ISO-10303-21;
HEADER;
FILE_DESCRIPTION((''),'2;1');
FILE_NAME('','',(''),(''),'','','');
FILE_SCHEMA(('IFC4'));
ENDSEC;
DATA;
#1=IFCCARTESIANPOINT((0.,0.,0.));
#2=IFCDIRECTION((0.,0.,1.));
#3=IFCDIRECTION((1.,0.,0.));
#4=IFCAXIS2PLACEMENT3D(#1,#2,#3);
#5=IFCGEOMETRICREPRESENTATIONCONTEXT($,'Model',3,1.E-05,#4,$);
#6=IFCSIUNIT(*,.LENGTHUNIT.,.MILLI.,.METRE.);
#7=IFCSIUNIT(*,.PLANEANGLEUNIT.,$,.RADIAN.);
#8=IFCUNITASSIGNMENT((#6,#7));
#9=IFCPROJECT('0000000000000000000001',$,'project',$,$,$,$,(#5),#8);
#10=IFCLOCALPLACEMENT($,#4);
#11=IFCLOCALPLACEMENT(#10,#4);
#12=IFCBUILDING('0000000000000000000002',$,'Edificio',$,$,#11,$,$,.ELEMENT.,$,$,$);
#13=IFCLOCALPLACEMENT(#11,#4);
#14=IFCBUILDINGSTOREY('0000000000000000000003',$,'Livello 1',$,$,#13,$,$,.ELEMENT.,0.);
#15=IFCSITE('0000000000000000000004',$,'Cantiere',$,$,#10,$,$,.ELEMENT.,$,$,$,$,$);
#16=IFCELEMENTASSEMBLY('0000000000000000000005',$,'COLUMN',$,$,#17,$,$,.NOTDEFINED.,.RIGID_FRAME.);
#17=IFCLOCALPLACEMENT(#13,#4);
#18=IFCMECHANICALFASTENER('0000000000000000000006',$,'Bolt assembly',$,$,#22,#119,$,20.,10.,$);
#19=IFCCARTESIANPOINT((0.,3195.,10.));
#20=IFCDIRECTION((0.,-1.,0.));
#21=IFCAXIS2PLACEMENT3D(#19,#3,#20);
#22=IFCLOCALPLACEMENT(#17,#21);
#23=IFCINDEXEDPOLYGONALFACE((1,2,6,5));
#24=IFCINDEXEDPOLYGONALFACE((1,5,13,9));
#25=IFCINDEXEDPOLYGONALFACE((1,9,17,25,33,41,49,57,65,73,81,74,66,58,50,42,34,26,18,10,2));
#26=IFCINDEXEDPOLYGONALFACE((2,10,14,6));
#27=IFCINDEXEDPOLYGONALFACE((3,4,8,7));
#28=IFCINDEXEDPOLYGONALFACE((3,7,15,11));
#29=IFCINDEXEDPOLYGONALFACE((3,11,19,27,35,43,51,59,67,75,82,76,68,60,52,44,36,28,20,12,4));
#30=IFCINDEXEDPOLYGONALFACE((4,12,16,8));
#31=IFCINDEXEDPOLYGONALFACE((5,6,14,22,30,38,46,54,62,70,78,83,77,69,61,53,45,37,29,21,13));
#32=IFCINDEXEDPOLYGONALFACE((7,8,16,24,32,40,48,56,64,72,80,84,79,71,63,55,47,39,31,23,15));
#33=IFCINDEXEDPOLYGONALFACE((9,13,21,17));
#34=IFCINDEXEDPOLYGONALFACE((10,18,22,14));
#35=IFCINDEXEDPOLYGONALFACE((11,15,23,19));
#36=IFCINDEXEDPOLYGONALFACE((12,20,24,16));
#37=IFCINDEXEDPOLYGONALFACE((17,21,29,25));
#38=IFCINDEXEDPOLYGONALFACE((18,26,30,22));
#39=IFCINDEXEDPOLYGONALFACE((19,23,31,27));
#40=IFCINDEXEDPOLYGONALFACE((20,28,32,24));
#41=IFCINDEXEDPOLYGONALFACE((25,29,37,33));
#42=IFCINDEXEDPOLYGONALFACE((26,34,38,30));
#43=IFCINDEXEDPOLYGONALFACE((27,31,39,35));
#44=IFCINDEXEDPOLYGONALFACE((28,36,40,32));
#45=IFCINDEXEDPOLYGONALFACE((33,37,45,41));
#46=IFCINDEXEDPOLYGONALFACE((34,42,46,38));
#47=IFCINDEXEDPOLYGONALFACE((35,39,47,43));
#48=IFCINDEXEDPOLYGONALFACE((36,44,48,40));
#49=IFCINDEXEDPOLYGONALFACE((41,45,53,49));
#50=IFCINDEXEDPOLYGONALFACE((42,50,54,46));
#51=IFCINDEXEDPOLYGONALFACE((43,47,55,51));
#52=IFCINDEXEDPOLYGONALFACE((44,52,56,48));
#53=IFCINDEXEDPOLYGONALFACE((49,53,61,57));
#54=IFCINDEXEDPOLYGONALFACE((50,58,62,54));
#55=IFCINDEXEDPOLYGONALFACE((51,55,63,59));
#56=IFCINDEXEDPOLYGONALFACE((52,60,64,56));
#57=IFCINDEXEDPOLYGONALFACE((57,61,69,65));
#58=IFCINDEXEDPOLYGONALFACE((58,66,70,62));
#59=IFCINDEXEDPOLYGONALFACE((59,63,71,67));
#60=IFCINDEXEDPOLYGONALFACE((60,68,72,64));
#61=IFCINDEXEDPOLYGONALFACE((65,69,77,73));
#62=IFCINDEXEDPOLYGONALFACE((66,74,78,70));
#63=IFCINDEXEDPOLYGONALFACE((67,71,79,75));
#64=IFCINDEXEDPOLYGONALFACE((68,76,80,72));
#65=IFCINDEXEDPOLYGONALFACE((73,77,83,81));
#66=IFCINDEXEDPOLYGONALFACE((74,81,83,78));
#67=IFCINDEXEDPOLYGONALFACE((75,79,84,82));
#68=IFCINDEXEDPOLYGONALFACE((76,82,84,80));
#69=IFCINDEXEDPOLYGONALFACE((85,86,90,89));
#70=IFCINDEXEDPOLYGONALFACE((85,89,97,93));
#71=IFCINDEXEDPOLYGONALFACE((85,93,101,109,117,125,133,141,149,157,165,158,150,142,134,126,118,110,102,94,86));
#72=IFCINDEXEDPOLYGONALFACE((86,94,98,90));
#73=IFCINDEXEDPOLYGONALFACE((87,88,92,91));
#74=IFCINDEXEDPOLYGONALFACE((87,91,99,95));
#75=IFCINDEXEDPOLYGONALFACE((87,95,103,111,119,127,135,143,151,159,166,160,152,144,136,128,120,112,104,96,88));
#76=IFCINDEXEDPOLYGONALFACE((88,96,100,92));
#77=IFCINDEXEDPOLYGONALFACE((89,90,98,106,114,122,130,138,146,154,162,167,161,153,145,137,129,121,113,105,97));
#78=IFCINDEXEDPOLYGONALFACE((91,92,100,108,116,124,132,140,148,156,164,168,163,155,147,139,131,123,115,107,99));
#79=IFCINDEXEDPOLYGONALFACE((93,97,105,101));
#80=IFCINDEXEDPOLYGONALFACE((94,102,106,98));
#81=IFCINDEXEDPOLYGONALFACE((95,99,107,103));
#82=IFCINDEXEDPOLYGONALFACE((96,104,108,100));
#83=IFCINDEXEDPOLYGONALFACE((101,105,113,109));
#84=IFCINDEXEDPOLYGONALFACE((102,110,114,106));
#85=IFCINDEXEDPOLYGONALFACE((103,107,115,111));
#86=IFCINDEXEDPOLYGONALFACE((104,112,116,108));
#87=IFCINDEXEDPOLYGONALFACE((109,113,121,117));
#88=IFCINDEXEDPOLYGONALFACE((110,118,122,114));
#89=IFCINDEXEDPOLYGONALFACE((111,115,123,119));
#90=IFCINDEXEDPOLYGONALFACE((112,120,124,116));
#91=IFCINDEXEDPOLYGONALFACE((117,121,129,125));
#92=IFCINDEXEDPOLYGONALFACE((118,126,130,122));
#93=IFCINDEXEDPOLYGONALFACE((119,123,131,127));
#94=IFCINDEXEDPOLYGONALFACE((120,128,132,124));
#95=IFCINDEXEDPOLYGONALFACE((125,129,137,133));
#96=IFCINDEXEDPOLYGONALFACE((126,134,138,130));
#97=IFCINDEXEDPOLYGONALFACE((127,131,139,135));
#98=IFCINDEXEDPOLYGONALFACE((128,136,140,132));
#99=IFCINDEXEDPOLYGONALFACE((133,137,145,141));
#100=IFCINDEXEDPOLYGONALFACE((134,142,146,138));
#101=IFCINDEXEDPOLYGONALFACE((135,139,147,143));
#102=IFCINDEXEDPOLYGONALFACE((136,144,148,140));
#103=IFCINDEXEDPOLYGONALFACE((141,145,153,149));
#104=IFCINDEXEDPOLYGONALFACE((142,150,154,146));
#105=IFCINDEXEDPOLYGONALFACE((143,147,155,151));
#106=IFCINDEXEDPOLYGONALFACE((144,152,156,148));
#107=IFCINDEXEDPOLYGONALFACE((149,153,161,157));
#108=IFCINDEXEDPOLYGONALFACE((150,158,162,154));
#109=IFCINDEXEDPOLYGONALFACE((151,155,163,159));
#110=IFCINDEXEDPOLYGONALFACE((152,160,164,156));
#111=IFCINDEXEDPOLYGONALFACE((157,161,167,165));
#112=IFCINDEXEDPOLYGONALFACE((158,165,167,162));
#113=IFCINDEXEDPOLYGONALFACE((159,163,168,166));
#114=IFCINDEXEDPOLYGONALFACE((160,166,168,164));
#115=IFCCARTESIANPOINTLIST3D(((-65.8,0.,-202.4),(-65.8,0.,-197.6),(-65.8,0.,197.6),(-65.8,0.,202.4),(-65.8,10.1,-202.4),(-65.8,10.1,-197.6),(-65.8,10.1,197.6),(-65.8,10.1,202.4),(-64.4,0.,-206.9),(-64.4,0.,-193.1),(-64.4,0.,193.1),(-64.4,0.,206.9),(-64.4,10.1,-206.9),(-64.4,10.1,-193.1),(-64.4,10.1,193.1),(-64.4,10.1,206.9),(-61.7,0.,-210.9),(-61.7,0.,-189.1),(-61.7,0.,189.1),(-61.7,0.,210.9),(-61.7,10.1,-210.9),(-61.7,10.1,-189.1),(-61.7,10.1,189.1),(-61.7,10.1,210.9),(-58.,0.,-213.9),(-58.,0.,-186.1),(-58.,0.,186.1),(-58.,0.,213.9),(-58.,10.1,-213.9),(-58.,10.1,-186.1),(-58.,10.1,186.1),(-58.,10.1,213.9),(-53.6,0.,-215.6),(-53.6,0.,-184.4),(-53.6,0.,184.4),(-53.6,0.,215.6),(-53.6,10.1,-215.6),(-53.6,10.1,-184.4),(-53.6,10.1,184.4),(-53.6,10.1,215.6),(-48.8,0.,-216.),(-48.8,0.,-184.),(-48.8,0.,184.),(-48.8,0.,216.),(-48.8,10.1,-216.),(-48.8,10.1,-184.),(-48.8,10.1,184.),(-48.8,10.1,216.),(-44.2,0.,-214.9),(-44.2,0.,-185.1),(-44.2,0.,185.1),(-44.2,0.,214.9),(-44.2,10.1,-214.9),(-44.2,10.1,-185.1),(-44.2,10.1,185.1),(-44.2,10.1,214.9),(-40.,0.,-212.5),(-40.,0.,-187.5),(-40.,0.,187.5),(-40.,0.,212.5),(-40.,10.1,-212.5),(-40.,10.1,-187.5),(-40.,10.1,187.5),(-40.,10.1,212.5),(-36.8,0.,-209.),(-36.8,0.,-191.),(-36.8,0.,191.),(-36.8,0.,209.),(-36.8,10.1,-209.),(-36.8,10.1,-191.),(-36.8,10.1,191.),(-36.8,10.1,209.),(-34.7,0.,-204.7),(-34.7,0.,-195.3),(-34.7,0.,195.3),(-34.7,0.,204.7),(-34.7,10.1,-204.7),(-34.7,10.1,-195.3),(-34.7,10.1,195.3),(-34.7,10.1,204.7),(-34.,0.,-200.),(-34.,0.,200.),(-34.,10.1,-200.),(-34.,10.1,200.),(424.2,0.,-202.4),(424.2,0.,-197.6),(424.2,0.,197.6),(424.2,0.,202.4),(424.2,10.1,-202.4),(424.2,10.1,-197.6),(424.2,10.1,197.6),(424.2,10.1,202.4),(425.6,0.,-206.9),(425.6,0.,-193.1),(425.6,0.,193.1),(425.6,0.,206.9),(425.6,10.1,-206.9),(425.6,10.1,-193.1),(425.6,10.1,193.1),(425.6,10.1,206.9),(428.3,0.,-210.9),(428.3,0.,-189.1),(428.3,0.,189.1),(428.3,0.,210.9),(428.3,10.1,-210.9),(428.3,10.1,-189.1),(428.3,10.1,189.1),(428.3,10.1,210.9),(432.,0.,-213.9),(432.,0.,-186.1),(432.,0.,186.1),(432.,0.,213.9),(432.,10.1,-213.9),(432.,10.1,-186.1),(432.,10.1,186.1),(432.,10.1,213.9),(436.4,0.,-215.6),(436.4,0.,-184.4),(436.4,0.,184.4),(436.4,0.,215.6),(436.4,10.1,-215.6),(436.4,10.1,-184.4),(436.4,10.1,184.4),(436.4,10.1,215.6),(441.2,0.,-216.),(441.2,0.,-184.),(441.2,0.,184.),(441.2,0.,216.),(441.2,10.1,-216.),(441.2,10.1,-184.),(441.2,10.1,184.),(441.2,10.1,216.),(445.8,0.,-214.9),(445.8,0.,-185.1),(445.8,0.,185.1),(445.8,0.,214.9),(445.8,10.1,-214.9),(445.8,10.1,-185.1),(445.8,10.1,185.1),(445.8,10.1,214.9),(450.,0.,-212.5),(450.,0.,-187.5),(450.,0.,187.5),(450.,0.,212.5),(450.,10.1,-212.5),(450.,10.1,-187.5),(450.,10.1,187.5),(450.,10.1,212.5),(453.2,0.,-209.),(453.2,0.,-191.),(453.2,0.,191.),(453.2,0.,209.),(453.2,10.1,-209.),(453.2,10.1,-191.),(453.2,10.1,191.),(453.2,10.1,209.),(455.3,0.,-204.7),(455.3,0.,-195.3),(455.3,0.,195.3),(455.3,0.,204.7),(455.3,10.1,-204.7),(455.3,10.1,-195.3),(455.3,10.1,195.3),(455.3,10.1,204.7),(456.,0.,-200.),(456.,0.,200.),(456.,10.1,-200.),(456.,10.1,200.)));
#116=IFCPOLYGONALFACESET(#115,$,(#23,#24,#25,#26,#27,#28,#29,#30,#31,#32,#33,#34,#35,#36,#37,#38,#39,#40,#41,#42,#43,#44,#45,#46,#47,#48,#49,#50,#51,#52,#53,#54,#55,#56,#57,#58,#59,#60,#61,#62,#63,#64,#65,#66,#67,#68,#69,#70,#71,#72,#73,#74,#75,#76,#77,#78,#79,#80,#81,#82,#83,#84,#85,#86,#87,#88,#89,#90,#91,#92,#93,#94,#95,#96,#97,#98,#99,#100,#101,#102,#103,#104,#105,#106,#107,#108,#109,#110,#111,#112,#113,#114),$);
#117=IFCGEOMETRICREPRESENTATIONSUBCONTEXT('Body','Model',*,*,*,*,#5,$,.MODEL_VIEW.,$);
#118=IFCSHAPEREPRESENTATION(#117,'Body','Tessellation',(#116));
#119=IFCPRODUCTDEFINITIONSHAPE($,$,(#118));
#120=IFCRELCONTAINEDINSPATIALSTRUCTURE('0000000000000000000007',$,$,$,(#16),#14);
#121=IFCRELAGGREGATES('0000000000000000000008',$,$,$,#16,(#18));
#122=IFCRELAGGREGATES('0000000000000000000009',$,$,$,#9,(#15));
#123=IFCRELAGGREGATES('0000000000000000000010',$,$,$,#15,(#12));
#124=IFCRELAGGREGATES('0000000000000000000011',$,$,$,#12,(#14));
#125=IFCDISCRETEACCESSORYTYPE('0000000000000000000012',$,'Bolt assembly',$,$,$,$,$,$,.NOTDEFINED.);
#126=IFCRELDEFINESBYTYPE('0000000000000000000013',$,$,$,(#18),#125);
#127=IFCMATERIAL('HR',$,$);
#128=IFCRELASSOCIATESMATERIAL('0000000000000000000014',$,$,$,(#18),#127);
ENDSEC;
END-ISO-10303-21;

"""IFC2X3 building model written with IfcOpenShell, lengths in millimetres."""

from ifc_helpers import new_model, si_unit, frame, origin_with_axes, origin_2d_with_axis, place, context, subcontext, project, spatial, circle, extrude, source, transform, mapped, material, type_object, element, aggregate, save


model = new_model("IFC2X3")

# Units and contexts
model_context = context("Model", 3, precision=1e-05, world=origin_with_axes())
body_context = subcontext(model_context, "Body", "Model", "MODEL_VIEW")
ifc_project = project(units=[si_unit("LENGTHUNIT", "METRE", prefix="MILLI"), si_unit("PLANEANGLEUNIT", "RADIAN")], contexts=[model_context])

# Site, building, storey
site_placement = place(None, origin_with_axes())
site = spatial("IfcSite", under=ifc_project, at=site_placement, Name="Cantiere", CompositionType="ELEMENT")
building_placement = place(site_placement, origin_with_axes())
building = spatial("IfcBuilding", under=site, at=building_placement, Name="Edificio", CompositionType="ELEMENT")
storey_placement = place(building_placement, origin_with_axes())
storey = spatial("IfcBuildingStorey", under=building, at=storey_placement, Name="Livello 1", CompositionType="ELEMENT", Elevation=0.0)

# Element assembly
assembly_1_placement = place(storey_placement, origin_with_axes())
assembly_1 = element("IfcElementAssembly", 1, at=assembly_1_placement, inside=storey, Name="COLUMN", AssemblyPlace="NOTDEFINED", PredefinedType="RIGID_FRAME")

# Mechanical fastener
ifc_material_1 = material(Name="HR")
discrete_accessory_type_1 = type_object("IfcDiscreteAccessoryType", Name="Bolt assembly")
shared_shape_1 = source(origin_with_axes(), body_context, "Body", "SweptSolid", [
    extrude(circle(Radius=16.0, at=origin_2d_with_axis()), frame((0.0, 0.0, 0.0), z_axis=(0.0, 1.0, 0.0), x_axis=(1.0, 0.0, 0.0)), (0.0, 0.0, 1.0), 10.1),
])
mechanical_fastener_1_placement = place(assembly_1_placement, frame((0.0, 3195.0, 10.0), z_axis=(1.0, 0.0, 0.0), x_axis=(0.0, -1.0, 0.0)))
mechanical_fastener_1 = element("IfcMechanicalFastener", 2, at=mechanical_fastener_1_placement, type_object=discrete_accessory_type_1, material=ifc_material_1, Name="Bolt assembly", NominalDiameter=20.0, NominalLength=10.0, context=body_context, shape_type="MappedRepresentation", body=[
    mapped(shared_shape_1, transform((-50.0, 0.0, -200.0))),
    mapped(shared_shape_1, transform((-50.0, 0.0, 200.0))),
    mapped(shared_shape_1, transform((440.0, 0.0, -200.0))),
    mapped(shared_shape_1, transform((440.0, 0.0, 200.0))),
])
aggregate(assembly_1, [mechanical_fastener_1])

save(model, "model.ifc")
